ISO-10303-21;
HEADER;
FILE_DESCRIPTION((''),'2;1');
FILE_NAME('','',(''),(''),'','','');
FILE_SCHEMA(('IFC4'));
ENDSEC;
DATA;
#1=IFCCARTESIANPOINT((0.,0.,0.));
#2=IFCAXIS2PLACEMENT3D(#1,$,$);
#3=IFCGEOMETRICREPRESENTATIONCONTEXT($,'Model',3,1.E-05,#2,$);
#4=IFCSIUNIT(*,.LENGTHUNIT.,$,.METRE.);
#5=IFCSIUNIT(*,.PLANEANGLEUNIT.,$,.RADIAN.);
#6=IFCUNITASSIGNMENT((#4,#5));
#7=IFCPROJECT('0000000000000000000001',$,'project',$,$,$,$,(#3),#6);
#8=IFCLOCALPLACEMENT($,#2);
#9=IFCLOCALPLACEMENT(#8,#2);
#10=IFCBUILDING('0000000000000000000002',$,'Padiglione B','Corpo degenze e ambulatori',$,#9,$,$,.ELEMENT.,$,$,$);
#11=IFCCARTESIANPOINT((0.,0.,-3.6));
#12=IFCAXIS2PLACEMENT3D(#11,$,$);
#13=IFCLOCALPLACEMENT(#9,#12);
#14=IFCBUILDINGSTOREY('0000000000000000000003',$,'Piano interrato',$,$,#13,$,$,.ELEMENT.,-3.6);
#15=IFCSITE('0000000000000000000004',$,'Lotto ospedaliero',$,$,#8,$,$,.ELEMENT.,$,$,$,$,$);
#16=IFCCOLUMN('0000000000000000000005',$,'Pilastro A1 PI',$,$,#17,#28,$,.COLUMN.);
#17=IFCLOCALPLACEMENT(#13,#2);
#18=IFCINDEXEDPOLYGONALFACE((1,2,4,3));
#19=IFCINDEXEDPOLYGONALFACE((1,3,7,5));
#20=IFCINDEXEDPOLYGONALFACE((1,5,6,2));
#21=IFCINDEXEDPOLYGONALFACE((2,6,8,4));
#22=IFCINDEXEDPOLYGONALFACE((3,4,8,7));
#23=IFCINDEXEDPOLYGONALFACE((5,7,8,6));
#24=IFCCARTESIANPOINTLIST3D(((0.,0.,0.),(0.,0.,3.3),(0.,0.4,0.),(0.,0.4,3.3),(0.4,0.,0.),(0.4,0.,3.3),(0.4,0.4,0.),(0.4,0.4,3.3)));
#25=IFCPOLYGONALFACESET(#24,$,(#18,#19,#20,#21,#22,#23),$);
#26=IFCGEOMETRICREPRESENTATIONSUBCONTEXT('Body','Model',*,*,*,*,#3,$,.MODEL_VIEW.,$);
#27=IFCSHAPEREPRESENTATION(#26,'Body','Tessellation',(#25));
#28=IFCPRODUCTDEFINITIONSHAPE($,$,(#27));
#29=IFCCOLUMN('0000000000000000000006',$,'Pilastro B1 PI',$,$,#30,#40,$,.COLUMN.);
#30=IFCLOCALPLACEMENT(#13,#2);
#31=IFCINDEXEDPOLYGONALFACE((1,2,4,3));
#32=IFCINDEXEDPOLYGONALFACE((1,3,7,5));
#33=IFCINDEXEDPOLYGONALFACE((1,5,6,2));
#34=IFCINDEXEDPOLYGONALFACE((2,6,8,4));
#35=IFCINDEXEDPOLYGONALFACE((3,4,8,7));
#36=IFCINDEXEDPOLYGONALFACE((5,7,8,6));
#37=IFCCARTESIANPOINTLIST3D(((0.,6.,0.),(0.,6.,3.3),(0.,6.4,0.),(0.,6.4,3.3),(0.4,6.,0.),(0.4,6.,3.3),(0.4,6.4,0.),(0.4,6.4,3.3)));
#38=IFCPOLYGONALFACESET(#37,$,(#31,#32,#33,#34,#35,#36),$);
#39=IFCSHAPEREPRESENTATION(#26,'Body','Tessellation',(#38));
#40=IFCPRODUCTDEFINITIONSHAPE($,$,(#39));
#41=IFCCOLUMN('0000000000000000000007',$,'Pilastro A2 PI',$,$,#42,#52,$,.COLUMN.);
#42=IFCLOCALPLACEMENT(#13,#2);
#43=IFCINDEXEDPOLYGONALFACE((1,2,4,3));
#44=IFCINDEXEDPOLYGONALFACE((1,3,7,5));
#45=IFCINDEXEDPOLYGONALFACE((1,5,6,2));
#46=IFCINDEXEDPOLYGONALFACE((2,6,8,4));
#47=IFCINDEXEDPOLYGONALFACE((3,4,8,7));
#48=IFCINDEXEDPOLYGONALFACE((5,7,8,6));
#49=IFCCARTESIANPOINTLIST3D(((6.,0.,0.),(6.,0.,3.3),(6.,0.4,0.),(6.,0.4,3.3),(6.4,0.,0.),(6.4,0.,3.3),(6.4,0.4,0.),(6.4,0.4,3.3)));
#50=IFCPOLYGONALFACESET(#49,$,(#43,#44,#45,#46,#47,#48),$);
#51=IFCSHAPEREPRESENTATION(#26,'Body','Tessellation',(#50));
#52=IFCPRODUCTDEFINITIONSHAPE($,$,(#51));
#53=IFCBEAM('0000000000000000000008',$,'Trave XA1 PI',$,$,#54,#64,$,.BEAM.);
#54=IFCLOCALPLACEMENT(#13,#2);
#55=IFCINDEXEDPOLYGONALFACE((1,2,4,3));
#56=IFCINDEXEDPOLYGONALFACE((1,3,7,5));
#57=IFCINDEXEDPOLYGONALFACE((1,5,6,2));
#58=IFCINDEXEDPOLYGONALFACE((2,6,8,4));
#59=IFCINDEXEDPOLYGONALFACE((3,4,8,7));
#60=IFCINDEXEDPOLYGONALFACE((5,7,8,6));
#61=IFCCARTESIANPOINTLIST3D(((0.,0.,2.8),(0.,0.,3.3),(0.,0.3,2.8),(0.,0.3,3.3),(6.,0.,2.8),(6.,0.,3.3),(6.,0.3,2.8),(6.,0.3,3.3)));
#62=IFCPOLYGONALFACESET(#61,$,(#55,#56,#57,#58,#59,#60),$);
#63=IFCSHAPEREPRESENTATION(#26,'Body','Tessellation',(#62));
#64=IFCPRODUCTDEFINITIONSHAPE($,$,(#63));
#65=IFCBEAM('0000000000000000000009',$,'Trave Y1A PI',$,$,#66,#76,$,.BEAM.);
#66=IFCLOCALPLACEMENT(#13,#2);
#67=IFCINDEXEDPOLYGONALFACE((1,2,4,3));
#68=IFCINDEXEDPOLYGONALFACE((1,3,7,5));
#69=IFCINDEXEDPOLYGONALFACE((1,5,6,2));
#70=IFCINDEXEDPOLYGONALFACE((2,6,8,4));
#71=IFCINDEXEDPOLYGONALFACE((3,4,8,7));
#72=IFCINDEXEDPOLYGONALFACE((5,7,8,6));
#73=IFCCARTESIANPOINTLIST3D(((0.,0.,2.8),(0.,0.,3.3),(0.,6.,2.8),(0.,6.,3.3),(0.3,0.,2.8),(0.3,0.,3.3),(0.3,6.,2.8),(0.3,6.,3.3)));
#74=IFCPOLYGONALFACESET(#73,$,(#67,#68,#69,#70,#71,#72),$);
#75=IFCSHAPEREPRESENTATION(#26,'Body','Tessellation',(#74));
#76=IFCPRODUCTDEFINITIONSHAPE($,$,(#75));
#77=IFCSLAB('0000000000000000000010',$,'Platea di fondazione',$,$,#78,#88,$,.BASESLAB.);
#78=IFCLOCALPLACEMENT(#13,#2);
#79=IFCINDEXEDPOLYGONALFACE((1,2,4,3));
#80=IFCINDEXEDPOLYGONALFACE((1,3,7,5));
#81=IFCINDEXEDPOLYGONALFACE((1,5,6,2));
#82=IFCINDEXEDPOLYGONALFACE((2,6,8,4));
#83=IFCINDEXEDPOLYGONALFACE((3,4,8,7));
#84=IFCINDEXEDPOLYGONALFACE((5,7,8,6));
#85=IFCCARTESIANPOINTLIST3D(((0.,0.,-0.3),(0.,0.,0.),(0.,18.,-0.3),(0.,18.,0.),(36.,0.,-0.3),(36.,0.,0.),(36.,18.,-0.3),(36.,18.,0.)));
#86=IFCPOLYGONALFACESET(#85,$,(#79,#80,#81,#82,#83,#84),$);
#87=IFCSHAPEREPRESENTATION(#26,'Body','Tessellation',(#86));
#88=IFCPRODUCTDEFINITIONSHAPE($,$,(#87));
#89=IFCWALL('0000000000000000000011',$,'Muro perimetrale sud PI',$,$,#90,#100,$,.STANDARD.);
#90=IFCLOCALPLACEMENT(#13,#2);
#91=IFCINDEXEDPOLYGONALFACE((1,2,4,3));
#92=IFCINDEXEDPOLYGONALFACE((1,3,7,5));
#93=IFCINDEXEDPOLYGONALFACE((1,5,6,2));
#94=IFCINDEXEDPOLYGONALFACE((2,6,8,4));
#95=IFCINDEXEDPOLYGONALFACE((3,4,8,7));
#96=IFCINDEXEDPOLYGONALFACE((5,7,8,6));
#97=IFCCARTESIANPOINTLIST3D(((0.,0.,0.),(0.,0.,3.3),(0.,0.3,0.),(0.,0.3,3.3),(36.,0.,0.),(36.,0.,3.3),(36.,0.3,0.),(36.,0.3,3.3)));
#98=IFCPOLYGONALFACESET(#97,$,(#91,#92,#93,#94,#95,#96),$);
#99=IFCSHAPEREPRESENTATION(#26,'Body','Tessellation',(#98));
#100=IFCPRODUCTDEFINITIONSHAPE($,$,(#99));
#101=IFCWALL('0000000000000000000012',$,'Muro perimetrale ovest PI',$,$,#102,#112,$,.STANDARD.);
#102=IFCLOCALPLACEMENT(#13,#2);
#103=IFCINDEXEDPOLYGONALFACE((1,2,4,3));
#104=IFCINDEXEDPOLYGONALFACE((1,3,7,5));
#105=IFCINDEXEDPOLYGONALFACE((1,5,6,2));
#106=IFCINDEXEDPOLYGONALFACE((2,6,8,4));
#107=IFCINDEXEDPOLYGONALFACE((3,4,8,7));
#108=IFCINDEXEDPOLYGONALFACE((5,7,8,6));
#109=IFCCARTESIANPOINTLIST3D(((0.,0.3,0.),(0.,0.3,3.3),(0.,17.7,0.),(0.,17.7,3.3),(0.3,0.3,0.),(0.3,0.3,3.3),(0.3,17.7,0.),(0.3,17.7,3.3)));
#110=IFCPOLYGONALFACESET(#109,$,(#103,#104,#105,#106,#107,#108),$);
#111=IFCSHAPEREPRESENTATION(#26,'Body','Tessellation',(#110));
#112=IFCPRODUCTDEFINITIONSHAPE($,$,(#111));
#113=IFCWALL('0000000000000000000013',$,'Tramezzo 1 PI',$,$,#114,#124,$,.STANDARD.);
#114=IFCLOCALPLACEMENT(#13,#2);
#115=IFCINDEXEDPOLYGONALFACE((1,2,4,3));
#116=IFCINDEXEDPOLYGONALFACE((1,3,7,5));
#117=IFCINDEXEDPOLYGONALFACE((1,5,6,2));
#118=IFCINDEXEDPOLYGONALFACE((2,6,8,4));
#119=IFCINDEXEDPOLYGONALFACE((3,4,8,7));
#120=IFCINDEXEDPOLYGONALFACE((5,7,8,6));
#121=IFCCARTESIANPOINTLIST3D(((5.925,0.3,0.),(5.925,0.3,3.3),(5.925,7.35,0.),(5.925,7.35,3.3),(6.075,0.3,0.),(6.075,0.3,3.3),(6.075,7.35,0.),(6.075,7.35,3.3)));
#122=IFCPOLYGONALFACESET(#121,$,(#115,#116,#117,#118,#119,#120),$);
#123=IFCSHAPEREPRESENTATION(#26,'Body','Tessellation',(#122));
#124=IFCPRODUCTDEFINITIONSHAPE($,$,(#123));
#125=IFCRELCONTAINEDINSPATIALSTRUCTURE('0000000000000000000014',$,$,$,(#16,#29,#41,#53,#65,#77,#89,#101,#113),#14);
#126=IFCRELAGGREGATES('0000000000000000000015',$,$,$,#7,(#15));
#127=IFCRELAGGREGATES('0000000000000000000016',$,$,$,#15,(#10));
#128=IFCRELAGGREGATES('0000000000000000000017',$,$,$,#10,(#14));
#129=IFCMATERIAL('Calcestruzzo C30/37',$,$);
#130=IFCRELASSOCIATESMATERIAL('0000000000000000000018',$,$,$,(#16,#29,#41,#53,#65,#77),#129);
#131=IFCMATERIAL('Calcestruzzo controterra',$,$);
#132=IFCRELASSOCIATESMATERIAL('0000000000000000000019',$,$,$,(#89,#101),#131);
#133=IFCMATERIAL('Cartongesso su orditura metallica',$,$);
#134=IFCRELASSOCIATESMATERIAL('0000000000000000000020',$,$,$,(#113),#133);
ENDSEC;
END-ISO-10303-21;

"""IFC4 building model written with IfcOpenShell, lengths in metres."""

from ifc_helpers import new_model, si_unit, frame, frame_2d, origin, place, context, subcontext, project, spatial, rectangle, extrude, material, element, save


model = new_model("IFC4")

# Units and contexts
model_context = context("Model", 3, precision=1e-05, world=origin())
body_context = subcontext(model_context, "Body", "Model", "MODEL_VIEW")
ifc_project = project(units=[si_unit("LENGTHUNIT", "METRE"), si_unit("PLANEANGLEUNIT", "RADIAN")], contexts=[model_context])

# Site, building, storey
site_placement = place(None, origin())
site = spatial("IfcSite", under=ifc_project, at=site_placement, Name="Lotto ospedaliero", CompositionType="ELEMENT")
building_placement = place(site_placement, origin())
building = spatial("IfcBuilding", under=site, at=building_placement, Name="Padiglione B", Description="Corpo degenze e ambulatori", CompositionType="ELEMENT")
storey_placement = place(building_placement, frame((0.0, 0.0, -3.6)))
storey = spatial("IfcBuildingStorey", under=building, at=storey_placement, Name="Piano interrato", CompositionType="ELEMENT", Elevation=-3.6)

# Columns
ifc_material_1 = material(Name="Calcestruzzo C30/37")
for number, where, name in (
    (1, (0.0, 0.0, 0.0), "Pilastro A1 PI"),
    (2, (0.0, 6.0, 0.0), "Pilastro B1 PI"),
    (3, (6.0, 0.0, 0.0), "Pilastro A2 PI"),
):
    element("IfcColumn", number, at=place(storey_placement, frame(where)), inside=storey, material=ifc_material_1, Name=name, PredefinedType="COLUMN", context=body_context, shape_type="SweptSolid", body=[
        extrude(rectangle(XDim=0.4, YDim=0.4, at=frame_2d((0.2, 0.2))), origin(), (0.0, 0.0, 1.0), 3.3),
    ])

# Beams
beam_1_placement = place(storey_placement, frame((0.0, 0.0, 2.8)))
element("IfcBeam", 4, at=beam_1_placement, inside=storey, material=ifc_material_1, Name="Trave XA1 PI", PredefinedType="BEAM", context=body_context, shape_type="SweptSolid", body=[
    extrude(rectangle(XDim=6.0, YDim=0.3, at=frame_2d((3.0, 0.15))), origin(), (0.0, 0.0, 1.0), 0.5),
])
beam_2_placement = place(storey_placement, frame((0.0, 0.0, 2.8)))
element("IfcBeam", 5, at=beam_2_placement, inside=storey, material=ifc_material_1, Name="Trave Y1A PI", PredefinedType="BEAM", context=body_context, shape_type="SweptSolid", body=[
    extrude(rectangle(XDim=0.3, YDim=6.0, at=frame_2d((0.15, 3.0))), origin(), (0.0, 0.0, 1.0), 0.5),
])

# Slab
slab_placement = place(storey_placement, frame((0.0, 0.0, -0.3)))
element("IfcSlab", 6, at=slab_placement, inside=storey, material=ifc_material_1, Name="Platea di fondazione", PredefinedType="BASESLAB", context=body_context, shape_type="SweptSolid", body=[
    extrude(rectangle(XDim=36.0, YDim=18.0, at=frame_2d((18.0, 9.0))), origin(), (0.0, 0.0, 1.0), 0.3),
])

# Walls
ifc_material_2 = material(Name="Calcestruzzo controterra")
wall_1_placement = place(storey_placement, origin())
element("IfcWall", 7, at=wall_1_placement, inside=storey, material=ifc_material_2, Name="Muro perimetrale sud PI", PredefinedType="STANDARD", context=body_context, shape_type="SweptSolid", body=[
    extrude(rectangle(XDim=36.0, YDim=0.3, at=frame_2d((18.0, 0.15))), origin(), (0.0, 0.0, 1.0), 3.3),
])
wall_2_placement = place(storey_placement, frame((0.0, 0.3, 0.0)))
element("IfcWall", 8, at=wall_2_placement, inside=storey, material=ifc_material_2, Name="Muro perimetrale ovest PI", PredefinedType="STANDARD", context=body_context, shape_type="SweptSolid", body=[
    extrude(rectangle(XDim=0.3, YDim=17.4, at=frame_2d((0.15, 8.7))), origin(), (0.0, 0.0, 1.0), 3.3),
])
ifc_material_3 = material(Name="Cartongesso su orditura metallica")
wall_3_placement = place(storey_placement, frame((5.925, 0.3, 0.0)))
element("IfcWall", 9, at=wall_3_placement, inside=storey, material=ifc_material_3, Name="Tramezzo 1 PI", PredefinedType="STANDARD", context=body_context, shape_type="SweptSolid", body=[
    extrude(rectangle(XDim=0.15, YDim=7.05, at=frame_2d((0.075, 3.525))), origin(), (0.0, 0.0, 1.0), 3.3),
])

save(model, "model.ifc")
